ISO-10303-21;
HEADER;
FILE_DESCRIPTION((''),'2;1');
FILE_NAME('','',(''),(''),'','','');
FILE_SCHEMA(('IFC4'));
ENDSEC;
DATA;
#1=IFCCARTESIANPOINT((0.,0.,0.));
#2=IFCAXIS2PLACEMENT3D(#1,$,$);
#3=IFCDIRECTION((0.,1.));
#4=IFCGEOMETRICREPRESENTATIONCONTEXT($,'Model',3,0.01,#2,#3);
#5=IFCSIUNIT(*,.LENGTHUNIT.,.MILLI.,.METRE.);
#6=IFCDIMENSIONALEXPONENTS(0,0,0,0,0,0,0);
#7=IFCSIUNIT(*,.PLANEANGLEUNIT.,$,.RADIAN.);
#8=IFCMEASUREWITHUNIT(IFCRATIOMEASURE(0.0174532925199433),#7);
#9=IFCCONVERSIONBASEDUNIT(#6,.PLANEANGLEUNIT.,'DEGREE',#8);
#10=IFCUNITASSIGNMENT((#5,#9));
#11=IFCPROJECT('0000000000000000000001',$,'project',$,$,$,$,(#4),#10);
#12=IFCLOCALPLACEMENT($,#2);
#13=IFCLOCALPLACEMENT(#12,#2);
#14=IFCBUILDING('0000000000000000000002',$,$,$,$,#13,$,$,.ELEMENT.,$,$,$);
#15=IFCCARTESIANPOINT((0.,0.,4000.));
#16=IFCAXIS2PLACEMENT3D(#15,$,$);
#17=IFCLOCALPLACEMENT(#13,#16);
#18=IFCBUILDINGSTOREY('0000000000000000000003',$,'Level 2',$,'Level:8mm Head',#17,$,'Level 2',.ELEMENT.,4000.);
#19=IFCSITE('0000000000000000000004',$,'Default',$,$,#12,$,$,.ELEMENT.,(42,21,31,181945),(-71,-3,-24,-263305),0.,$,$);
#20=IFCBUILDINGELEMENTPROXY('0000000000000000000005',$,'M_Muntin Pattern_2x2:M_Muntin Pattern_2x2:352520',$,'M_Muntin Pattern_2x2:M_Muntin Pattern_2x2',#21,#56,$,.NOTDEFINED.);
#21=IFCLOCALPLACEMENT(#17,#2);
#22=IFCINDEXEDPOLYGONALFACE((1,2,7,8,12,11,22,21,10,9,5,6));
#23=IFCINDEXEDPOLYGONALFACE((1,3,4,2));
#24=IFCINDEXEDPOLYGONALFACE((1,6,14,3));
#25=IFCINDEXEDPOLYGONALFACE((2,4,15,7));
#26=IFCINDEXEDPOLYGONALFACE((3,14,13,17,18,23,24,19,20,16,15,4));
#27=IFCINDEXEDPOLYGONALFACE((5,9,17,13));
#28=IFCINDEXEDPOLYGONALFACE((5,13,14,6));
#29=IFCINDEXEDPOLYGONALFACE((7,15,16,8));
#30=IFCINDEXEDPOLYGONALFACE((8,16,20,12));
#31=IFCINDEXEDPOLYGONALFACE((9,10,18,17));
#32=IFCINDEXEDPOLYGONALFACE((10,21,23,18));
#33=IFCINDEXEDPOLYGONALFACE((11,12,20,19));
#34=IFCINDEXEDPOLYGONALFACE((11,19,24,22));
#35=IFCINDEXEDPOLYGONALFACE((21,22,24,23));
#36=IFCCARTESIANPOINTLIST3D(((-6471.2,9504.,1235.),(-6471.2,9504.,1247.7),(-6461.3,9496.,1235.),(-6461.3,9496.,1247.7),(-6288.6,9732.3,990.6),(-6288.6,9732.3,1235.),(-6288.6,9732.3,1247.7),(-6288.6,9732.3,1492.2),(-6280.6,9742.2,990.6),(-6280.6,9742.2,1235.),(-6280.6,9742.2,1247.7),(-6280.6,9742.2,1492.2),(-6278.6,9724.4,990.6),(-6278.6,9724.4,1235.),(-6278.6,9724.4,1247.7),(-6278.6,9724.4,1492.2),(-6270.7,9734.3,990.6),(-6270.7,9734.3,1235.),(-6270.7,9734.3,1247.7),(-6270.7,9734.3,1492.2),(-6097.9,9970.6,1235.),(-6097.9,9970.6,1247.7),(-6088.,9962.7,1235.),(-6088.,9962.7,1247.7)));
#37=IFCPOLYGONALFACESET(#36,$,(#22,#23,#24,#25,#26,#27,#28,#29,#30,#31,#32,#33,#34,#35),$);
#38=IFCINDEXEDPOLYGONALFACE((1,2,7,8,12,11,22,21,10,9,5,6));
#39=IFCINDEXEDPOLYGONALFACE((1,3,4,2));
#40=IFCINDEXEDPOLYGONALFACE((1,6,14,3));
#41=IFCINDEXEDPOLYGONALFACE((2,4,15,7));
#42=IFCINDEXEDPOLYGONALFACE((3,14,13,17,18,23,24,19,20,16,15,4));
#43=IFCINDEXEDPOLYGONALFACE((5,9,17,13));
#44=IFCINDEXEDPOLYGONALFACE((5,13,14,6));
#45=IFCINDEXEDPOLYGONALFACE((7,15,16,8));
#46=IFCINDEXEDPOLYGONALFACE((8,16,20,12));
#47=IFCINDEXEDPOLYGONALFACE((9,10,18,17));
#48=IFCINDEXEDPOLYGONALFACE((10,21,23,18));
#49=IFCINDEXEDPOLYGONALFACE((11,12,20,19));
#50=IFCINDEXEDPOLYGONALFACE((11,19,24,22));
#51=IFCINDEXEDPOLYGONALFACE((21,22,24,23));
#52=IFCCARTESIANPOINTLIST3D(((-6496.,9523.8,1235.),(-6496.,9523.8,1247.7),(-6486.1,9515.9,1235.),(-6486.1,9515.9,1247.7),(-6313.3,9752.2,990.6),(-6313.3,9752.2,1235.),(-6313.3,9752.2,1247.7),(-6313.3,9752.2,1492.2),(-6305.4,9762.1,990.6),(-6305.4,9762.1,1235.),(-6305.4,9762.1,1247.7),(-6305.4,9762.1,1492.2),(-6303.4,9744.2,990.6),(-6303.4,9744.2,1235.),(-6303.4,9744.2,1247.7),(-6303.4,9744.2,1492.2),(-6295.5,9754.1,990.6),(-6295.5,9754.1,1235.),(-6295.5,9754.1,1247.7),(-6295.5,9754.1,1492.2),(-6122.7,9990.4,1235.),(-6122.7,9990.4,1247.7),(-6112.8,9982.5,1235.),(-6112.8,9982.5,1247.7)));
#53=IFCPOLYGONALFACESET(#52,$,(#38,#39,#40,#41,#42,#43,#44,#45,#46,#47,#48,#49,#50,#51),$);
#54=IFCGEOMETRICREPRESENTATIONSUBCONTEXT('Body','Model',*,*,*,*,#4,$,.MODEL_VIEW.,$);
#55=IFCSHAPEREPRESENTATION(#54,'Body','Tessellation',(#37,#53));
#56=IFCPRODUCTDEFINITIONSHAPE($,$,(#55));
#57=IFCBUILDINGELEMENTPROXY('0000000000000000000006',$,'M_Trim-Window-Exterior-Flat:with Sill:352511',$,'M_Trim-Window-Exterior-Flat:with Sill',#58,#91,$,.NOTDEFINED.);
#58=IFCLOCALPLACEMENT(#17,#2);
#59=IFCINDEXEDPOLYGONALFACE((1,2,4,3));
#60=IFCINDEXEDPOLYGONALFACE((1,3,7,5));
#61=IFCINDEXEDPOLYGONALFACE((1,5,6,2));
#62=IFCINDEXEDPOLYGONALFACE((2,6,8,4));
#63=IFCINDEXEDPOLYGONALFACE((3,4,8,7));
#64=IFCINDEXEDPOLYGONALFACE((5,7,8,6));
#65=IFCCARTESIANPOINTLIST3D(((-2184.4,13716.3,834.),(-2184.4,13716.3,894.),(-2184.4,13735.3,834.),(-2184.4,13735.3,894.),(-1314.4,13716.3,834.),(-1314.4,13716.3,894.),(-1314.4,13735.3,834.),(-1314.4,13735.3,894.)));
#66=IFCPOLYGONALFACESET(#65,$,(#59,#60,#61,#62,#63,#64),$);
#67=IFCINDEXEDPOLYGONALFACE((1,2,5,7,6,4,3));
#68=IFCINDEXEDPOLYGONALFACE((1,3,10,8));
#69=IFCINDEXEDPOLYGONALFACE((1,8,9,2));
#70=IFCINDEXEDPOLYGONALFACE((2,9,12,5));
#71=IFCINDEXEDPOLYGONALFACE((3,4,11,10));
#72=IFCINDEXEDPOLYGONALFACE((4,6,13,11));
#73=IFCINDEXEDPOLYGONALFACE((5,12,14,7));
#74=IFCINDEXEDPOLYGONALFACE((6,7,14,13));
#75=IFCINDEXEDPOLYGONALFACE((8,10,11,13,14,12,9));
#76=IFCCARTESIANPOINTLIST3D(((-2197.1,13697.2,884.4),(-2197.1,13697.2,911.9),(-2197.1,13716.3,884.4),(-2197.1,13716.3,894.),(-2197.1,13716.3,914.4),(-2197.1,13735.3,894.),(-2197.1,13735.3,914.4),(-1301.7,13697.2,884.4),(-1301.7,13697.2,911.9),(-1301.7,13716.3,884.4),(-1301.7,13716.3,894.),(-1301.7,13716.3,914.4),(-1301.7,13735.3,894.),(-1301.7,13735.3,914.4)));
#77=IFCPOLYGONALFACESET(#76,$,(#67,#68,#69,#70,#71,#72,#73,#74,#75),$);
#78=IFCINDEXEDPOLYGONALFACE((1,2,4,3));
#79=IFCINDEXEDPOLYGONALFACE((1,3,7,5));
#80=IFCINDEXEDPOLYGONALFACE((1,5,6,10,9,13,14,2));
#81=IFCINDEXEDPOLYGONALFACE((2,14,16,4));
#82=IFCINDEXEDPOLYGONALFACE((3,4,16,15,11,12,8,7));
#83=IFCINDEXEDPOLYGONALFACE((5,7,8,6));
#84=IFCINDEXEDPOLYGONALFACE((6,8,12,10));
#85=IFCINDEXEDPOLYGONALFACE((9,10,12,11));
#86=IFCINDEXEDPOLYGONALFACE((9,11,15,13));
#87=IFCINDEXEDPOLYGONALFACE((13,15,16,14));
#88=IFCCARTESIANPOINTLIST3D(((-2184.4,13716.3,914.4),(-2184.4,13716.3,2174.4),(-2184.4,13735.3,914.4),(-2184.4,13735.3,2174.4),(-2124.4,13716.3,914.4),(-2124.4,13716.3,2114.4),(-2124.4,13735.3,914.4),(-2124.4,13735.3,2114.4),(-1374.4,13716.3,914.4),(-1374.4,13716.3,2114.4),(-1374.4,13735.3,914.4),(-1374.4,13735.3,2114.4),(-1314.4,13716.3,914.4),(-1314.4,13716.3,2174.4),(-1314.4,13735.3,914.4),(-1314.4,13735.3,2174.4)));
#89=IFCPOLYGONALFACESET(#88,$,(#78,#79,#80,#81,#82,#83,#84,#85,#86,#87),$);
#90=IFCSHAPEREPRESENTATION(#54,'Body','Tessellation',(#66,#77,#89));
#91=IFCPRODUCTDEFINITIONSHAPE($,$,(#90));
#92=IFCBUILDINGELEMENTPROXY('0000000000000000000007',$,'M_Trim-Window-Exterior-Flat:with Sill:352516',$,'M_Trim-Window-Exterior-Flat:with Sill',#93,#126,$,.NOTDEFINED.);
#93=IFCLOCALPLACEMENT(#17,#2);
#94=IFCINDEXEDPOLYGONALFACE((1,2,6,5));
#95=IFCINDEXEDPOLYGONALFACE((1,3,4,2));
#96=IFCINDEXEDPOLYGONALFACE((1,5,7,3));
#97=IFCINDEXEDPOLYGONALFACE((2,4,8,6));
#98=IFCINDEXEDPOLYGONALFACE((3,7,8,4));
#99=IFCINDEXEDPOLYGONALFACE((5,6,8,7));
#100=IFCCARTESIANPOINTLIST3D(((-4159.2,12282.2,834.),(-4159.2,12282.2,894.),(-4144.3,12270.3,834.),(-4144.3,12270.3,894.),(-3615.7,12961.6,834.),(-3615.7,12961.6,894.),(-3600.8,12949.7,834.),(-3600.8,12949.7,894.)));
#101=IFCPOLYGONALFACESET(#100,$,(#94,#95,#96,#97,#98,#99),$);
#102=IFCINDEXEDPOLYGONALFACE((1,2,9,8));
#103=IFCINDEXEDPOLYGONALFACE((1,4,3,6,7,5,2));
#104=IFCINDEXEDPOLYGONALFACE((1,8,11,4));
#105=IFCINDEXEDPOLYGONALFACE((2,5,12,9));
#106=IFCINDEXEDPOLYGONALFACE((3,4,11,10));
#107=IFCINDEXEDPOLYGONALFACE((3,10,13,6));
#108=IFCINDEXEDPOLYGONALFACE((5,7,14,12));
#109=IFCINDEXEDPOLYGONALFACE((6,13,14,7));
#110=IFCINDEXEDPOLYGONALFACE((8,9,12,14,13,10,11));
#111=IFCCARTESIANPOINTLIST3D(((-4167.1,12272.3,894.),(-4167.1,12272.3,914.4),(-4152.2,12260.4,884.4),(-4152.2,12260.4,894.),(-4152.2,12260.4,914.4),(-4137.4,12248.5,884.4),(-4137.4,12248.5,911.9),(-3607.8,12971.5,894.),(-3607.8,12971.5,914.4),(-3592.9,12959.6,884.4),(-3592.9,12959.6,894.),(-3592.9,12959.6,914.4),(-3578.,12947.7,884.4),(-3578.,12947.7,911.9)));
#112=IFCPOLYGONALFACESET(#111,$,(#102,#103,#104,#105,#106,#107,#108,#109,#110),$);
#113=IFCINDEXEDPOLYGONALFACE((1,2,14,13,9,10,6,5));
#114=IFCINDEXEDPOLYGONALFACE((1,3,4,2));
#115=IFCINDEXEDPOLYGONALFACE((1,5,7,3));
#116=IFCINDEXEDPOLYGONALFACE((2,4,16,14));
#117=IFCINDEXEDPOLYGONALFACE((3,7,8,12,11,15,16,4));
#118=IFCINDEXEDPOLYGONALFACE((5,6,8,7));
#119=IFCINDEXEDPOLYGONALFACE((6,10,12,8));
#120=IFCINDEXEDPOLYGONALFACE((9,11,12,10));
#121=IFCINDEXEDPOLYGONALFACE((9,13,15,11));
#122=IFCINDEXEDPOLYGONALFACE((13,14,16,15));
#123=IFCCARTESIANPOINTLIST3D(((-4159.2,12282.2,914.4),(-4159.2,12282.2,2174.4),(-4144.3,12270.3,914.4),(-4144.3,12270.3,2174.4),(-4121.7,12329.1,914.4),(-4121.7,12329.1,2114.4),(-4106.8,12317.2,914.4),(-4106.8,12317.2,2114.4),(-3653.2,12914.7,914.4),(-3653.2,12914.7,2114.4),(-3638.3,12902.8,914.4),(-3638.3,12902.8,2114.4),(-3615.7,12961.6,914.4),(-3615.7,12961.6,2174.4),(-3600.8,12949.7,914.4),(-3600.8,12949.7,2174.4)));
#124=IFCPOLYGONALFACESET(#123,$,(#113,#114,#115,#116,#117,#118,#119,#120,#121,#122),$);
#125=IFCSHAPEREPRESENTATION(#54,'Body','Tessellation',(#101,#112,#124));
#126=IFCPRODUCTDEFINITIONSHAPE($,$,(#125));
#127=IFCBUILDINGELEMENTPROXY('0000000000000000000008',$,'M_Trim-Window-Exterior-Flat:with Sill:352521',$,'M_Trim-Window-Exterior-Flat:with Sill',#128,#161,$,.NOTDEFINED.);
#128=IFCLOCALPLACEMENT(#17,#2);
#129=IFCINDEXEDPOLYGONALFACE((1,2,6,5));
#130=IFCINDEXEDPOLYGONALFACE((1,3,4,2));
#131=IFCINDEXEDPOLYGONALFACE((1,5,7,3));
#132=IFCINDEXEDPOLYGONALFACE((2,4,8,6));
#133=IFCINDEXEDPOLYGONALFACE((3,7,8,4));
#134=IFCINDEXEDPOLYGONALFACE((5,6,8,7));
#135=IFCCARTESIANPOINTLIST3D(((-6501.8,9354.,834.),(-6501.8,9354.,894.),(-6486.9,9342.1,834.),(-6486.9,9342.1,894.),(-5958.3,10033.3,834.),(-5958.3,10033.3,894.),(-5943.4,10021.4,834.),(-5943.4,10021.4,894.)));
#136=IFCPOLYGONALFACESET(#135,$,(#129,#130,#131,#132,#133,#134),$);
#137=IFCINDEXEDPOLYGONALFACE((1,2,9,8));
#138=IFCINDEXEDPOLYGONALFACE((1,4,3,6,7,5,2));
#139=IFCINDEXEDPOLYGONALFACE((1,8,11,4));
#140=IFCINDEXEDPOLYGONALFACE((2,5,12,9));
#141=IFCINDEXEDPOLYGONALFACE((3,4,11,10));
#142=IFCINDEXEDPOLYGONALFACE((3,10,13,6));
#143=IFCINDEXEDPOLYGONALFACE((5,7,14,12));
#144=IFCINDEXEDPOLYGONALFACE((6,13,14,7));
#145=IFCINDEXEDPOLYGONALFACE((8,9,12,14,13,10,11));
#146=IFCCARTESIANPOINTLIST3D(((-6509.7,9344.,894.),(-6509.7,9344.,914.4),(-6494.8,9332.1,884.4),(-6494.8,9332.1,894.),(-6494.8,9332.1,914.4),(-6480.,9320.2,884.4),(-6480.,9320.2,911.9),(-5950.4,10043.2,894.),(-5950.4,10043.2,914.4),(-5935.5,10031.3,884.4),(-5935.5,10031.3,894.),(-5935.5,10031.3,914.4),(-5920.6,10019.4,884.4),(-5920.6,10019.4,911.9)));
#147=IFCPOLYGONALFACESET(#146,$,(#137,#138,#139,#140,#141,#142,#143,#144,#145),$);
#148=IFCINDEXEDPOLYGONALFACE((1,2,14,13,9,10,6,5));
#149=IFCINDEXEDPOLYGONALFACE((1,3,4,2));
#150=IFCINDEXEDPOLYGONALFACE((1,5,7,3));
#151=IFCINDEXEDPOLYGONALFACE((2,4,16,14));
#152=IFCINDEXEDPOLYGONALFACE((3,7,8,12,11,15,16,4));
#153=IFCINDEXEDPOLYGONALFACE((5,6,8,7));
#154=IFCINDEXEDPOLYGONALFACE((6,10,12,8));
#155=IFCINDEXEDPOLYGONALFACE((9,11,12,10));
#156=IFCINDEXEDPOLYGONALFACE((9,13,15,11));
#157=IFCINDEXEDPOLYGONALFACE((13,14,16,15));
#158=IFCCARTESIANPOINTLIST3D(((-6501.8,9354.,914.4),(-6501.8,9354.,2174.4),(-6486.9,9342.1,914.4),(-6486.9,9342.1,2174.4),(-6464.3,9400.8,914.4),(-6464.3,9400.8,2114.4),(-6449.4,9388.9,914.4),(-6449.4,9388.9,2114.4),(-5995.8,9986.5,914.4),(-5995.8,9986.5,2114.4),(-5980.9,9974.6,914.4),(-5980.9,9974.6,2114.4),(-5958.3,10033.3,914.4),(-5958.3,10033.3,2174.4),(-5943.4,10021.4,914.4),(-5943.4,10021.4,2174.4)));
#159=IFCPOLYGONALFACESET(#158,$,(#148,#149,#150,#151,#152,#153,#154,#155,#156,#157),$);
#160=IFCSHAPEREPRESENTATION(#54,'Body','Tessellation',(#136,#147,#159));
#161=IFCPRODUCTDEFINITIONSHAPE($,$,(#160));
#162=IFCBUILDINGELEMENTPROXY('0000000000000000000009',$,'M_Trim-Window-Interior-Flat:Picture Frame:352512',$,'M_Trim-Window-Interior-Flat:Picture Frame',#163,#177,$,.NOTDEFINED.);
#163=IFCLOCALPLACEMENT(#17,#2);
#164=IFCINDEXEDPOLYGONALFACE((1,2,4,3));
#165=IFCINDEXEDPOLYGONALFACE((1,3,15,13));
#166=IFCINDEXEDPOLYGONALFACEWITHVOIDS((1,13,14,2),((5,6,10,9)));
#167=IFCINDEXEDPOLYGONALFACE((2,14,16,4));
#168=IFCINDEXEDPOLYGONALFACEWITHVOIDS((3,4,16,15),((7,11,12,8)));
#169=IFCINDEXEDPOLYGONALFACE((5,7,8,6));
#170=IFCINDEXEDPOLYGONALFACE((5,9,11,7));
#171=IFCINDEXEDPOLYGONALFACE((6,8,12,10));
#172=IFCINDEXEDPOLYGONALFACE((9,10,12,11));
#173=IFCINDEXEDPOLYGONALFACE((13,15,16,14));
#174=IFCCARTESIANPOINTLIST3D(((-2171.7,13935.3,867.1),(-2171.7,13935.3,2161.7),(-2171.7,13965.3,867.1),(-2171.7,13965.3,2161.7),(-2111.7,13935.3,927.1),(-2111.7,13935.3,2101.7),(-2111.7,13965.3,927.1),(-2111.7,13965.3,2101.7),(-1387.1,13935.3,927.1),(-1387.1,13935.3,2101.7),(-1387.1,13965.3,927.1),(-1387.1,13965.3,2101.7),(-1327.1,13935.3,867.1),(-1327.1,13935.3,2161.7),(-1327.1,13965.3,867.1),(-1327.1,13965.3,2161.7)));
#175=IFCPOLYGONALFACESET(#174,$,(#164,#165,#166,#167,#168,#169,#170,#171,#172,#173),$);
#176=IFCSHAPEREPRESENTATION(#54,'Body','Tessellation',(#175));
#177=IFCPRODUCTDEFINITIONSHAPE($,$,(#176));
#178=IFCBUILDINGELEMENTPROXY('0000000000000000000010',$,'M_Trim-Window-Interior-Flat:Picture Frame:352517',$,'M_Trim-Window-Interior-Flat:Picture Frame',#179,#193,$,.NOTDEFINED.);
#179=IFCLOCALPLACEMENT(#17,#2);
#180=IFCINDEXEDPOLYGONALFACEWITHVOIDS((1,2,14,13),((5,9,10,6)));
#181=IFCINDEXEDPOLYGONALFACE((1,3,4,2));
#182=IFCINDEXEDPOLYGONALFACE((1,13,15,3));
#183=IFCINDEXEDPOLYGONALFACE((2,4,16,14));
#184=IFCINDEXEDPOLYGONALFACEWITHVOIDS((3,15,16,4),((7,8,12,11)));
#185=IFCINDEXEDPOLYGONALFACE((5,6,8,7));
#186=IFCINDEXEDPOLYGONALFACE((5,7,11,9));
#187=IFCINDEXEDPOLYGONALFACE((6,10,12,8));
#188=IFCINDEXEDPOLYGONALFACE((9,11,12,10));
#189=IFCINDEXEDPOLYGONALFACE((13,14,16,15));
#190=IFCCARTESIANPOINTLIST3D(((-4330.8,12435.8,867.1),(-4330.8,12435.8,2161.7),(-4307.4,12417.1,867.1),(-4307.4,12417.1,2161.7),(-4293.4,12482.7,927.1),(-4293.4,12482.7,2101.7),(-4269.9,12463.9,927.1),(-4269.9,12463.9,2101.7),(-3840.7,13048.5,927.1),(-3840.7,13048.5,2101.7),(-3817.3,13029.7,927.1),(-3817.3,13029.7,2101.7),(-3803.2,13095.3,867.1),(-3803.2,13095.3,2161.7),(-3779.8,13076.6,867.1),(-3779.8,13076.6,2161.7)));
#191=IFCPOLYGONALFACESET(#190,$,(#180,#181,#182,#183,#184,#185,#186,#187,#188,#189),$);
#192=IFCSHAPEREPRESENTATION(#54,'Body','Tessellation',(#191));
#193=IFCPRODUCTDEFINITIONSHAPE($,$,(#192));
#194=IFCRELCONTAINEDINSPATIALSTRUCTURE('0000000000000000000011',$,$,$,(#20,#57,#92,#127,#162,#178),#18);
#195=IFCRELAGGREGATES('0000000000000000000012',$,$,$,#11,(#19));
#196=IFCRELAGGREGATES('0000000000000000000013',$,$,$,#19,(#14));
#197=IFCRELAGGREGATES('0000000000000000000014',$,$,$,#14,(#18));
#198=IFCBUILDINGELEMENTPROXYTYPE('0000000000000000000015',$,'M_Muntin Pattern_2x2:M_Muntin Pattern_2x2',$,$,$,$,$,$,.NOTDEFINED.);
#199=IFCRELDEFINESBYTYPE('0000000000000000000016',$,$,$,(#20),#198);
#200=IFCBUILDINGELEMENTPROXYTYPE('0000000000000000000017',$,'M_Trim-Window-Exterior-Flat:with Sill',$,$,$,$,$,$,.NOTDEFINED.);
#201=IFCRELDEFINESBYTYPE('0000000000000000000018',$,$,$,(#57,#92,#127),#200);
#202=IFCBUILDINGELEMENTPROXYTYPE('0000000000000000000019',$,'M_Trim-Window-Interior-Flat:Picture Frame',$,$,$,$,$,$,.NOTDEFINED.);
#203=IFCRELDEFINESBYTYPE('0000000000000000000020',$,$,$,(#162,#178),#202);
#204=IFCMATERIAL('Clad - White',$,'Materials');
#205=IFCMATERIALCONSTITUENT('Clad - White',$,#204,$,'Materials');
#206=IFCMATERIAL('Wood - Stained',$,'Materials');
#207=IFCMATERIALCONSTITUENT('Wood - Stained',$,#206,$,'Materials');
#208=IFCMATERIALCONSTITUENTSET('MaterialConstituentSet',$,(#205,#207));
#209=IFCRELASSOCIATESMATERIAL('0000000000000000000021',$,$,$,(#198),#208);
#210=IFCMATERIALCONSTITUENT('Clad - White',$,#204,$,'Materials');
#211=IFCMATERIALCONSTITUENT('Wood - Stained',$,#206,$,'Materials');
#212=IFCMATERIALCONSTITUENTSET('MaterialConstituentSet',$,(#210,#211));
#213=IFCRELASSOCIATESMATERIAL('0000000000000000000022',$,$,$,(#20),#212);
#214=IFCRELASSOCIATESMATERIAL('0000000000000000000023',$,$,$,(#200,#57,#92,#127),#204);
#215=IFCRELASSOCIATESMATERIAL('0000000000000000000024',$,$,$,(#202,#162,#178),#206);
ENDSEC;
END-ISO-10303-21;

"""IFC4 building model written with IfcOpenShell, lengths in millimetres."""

from ifc_helpers import new_model, entity, si_unit, converted_unit, direction, frame, frame_2d, origin, place, context, subcontext, project, spatial, polyline, rectangle, outline, extrude, source, transform, mapped, material, constituent, constituent_set, type_object, type_shapes, element, save


model = new_model("IFC4")

# Units and contexts
model_context = context("Model", 3, precision=0.01, world=origin(), true_north=direction((0.0, 1.0)))
body_context = subcontext(model_context, "Body", "Model", "MODEL_VIEW")
ifc_project = project(units=[si_unit("LENGTHUNIT", "METRE", prefix="MILLI"), converted_unit("PLANEANGLEUNIT", "DEGREE", entity("IfcRatioMeasure", 0.0174532925199433), si_unit("PLANEANGLEUNIT", "RADIAN"), dimensions=[0, 0, 0, 0, 0, 0, 0])], contexts=[model_context])

# Site, building, storey
site_placement = place(None, origin())
site = spatial("IfcSite", under=ifc_project, at=site_placement, Name="Default", CompositionType="ELEMENT", RefLatitude=(42, 21, 31, 181945), RefLongitude=(-71, -3, -24, -263305), RefElevation=0.0)
building_placement = place(site_placement, origin())
building = spatial("IfcBuilding", under=site, at=building_placement, CompositionType="ELEMENT")
storey_placement = place(building_placement, frame((0.0, 0.0, 4000.0)))
storey = spatial("IfcBuildingStorey", under=building, at=storey_placement, Name="Level 2", ObjectType="Level:8mm Head", LongName="Level 2", CompositionType="ELEMENT", Elevation=4000.0)

# Shared definitions
ifc_material_1 = material(Name="Wood - Stained", Category="Materials")

# Building element proxies
ifc_material_2 = material(Name="Clad - White", Category="Materials")
ifc_constituent_1 = constituent(ifc_material_2, Name="Clad - White", Category="Materials")
ifc_constituent_2 = constituent(ifc_material_1, Name="Wood - Stained", Category="Materials")
ifc_constituent_set_1 = constituent_set(constituents=[ifc_constituent_1, ifc_constituent_2], Name="MaterialConstituentSet")
building_element_proxy_type_1 = type_object("IfcBuildingElementProxyType", Name="M_Muntin Pattern_2x2:M_Muntin Pattern_2x2", PredefinedType="NOTDEFINED", material=ifc_constituent_set_1)
shared_shape_1 = source(origin(), body_context, "Body", "SweptSolid", [
    extrude(outline(polyline([(6.4, -6.4), (250.8, -6.4), (250.8, 6.3), (6.4, 6.3), (6.4, 298.8), (-6.3, 298.8), (-6.3, 6.3), (-250.8, 6.3), (-250.8, -6.4), (-6.3, -6.4), (-6.3, -298.8), (6.4, -298.8), (6.4, -6.4)])), frame((0.0, 9.5, 250.8), z_axis=(0.0, 1.0, 0.0), x_axis=(0.0, 0.0, 1.0)), (0.0, 0.0, 1.0), 12.7),
    extrude(outline(polyline([(6.4, -6.4), (250.8, -6.4), (250.8, 6.3), (6.4, 6.3), (6.4, 298.8), (-6.3, 298.8), (-6.3, 6.3), (-250.8, 6.3), (-250.8, -6.4), (-6.3, -6.4), (-6.3, -298.8), (6.4, -298.8), (6.4, -6.4)])), frame((0.0, -22.2, 250.8), z_axis=(0.0, 1.0, 0.0), x_axis=(0.0, 0.0, 1.0)), (0.0, 0.0, 1.0), 12.7),
])
type_shapes(building_element_proxy_type_1, [shared_shape_1])
ifc_constituent_3 = constituent(ifc_material_2, Name="Clad - White", Category="Materials")
ifc_constituent_4 = constituent(ifc_material_1, Name="Wood - Stained", Category="Materials")
ifc_constituent_set_2 = constituent_set(constituents=[ifc_constituent_3, ifc_constituent_4], Name="MaterialConstituentSet")
proxy_1_placement = place(storey_placement, frame((-6292.0, 9743.2, 990.6), z_axis=(0.0, 0.0, 1.0), x_axis=(-0.624695, -0.780869, 0.0)))
element("IfcBuildingElementProxy", 1, at=proxy_1_placement, inside=storey, type_object=building_element_proxy_type_1, material=ifc_constituent_set_2, Name="M_Muntin Pattern_2x2:M_Muntin Pattern_2x2:352520", ObjectType="M_Muntin Pattern_2x2:M_Muntin Pattern_2x2", PredefinedType="NOTDEFINED", context=body_context, shape_type="MappedRepresentation", body=[
    mapped(shared_shape_1, transform((0.0, 0.0, 0.0), scale=1.0)),
])
building_element_proxy_type_2 = type_object("IfcBuildingElementProxyType", Name="M_Trim-Window-Exterior-Flat:with Sill", PredefinedType="NOTDEFINED", material=ifc_material_2)
shared_shape_2 = source(origin(), body_context, "Body", "SweptSolid", [
    extrude(rectangle(XDim=870.0, YDim=60.0, at=frame_2d((0.0, 0.0), x_axis=(1.0, 0.0))), frame((0.0, -1250.4, 0.0), z_axis=(0.0, 0.0, 1.0), x_axis=(-1.0, 0.0, 0.0)), (0.0, 0.0, 1.0), 19.1),
    extrude(outline(polyline([(-19.0, -15.2), (0.0, -15.2), (0.0, -5.7), (19.0, -5.7), (19.0, 14.8), (0.0, 14.8), (-19.0, 12.3), (-19.0, -15.2)])), frame((-447.7, -1214.8, 19.0), z_axis=(1.0, 0.0, 0.0), x_axis=(0.0, 0.0, -1.0)), (0.0, 0.0, 1.0), 895.4),
    extrude(outline(polyline([(-645.0, -435.0), (615.0, -435.0), (615.0, -375.0), (-585.0, -375.0), (-585.0, 375.0), (615.0, 375.0), (615.0, 435.0), (-645.0, 435.0), (-645.0, -435.0)])), frame((0.0, -585.0, 0.0), z_axis=(0.0, 0.0, 1.0), x_axis=(0.0, -1.0, 0.0)), (0.0, 0.0, 1.0), 19.1),
])
type_shapes(building_element_proxy_type_2, [shared_shape_2])
for number, where, z_axis, x_axis, name in (
    (2, (-1749.4, 13735.3, 2114.4), (0.0, -1.0, 0.0), (1.0, 0.0, 0.0), "M_Trim-Window-Exterior-Flat:with Sill:352511"),
    (3, (-3887.4, 12621.9, 2114.4), (0.780869, -0.624695, 0.0), (0.624695, 0.780869, 0.0), "M_Trim-Window-Exterior-Flat:with Sill:352516"),
    (4, (-6230.0, 9693.6, 2114.4), (0.780869, -0.624695, 0.0), (0.624695, 0.780869, 0.0), "M_Trim-Window-Exterior-Flat:with Sill:352521"),
):
    element("IfcBuildingElementProxy", number, at=place(storey_placement, frame(where, z_axis=z_axis, x_axis=x_axis)), inside=storey, type_object=building_element_proxy_type_2, material=ifc_material_2, Name=name, ObjectType="M_Trim-Window-Exterior-Flat:with Sill", PredefinedType="NOTDEFINED", context=body_context, shape_type="MappedRepresentation", body=[
        mapped(shared_shape_2, transform((0.0, 0.0, 0.0), scale=1.0)),
    ])
building_element_proxy_type_3 = type_object("IfcBuildingElementProxyType", Name="M_Trim-Window-Interior-Flat:Picture Frame", PredefinedType="NOTDEFINED", material=ifc_material_1)
shared_shape_3 = source(origin(), body_context, "Body", "SweptSolid", [
    extrude(outline(polyline([(-422.3, -647.3), (422.3, -647.3), (422.3, 647.3), (-422.3, 647.3), (-422.3, -647.3)]), holes=[polyline([(-362.3, -587.3), (-362.3, 587.3), (362.3, 587.3), (362.3, -587.3), (-362.3, -587.3)])]), frame((0.0, -600.0, 0.0), z_axis=(0.0, 0.0, 1.0), x_axis=(-1.0, 0.0, 0.0)), (0.0, 0.0, 1.0), 30.0),
])
type_shapes(building_element_proxy_type_3, [shared_shape_3])
for number, where, z_axis, x_axis, name in (
    (5, (-1749.4, 13935.3, 2114.4), (0.0, 1.0, 0.0), (-1.0, 0.0, 0.0), "M_Trim-Window-Interior-Flat:Picture Frame:352512"),
    (6, (-4043.6, 12746.8, 2114.4), (-0.780869, 0.624695, 0.0), (-0.624695, -0.780869, 0.0), "M_Trim-Window-Interior-Flat:Picture Frame:352517"),
):
    element("IfcBuildingElementProxy", number, at=place(storey_placement, frame(where, z_axis=z_axis, x_axis=x_axis)), inside=storey, type_object=building_element_proxy_type_3, material=ifc_material_1, Name=name, ObjectType="M_Trim-Window-Interior-Flat:Picture Frame", PredefinedType="NOTDEFINED", context=body_context, shape_type="MappedRepresentation", body=[
        mapped(shared_shape_3, transform((0.0, 0.0, 0.0), scale=1.0)),
    ])

save(model, "model.ifc")
